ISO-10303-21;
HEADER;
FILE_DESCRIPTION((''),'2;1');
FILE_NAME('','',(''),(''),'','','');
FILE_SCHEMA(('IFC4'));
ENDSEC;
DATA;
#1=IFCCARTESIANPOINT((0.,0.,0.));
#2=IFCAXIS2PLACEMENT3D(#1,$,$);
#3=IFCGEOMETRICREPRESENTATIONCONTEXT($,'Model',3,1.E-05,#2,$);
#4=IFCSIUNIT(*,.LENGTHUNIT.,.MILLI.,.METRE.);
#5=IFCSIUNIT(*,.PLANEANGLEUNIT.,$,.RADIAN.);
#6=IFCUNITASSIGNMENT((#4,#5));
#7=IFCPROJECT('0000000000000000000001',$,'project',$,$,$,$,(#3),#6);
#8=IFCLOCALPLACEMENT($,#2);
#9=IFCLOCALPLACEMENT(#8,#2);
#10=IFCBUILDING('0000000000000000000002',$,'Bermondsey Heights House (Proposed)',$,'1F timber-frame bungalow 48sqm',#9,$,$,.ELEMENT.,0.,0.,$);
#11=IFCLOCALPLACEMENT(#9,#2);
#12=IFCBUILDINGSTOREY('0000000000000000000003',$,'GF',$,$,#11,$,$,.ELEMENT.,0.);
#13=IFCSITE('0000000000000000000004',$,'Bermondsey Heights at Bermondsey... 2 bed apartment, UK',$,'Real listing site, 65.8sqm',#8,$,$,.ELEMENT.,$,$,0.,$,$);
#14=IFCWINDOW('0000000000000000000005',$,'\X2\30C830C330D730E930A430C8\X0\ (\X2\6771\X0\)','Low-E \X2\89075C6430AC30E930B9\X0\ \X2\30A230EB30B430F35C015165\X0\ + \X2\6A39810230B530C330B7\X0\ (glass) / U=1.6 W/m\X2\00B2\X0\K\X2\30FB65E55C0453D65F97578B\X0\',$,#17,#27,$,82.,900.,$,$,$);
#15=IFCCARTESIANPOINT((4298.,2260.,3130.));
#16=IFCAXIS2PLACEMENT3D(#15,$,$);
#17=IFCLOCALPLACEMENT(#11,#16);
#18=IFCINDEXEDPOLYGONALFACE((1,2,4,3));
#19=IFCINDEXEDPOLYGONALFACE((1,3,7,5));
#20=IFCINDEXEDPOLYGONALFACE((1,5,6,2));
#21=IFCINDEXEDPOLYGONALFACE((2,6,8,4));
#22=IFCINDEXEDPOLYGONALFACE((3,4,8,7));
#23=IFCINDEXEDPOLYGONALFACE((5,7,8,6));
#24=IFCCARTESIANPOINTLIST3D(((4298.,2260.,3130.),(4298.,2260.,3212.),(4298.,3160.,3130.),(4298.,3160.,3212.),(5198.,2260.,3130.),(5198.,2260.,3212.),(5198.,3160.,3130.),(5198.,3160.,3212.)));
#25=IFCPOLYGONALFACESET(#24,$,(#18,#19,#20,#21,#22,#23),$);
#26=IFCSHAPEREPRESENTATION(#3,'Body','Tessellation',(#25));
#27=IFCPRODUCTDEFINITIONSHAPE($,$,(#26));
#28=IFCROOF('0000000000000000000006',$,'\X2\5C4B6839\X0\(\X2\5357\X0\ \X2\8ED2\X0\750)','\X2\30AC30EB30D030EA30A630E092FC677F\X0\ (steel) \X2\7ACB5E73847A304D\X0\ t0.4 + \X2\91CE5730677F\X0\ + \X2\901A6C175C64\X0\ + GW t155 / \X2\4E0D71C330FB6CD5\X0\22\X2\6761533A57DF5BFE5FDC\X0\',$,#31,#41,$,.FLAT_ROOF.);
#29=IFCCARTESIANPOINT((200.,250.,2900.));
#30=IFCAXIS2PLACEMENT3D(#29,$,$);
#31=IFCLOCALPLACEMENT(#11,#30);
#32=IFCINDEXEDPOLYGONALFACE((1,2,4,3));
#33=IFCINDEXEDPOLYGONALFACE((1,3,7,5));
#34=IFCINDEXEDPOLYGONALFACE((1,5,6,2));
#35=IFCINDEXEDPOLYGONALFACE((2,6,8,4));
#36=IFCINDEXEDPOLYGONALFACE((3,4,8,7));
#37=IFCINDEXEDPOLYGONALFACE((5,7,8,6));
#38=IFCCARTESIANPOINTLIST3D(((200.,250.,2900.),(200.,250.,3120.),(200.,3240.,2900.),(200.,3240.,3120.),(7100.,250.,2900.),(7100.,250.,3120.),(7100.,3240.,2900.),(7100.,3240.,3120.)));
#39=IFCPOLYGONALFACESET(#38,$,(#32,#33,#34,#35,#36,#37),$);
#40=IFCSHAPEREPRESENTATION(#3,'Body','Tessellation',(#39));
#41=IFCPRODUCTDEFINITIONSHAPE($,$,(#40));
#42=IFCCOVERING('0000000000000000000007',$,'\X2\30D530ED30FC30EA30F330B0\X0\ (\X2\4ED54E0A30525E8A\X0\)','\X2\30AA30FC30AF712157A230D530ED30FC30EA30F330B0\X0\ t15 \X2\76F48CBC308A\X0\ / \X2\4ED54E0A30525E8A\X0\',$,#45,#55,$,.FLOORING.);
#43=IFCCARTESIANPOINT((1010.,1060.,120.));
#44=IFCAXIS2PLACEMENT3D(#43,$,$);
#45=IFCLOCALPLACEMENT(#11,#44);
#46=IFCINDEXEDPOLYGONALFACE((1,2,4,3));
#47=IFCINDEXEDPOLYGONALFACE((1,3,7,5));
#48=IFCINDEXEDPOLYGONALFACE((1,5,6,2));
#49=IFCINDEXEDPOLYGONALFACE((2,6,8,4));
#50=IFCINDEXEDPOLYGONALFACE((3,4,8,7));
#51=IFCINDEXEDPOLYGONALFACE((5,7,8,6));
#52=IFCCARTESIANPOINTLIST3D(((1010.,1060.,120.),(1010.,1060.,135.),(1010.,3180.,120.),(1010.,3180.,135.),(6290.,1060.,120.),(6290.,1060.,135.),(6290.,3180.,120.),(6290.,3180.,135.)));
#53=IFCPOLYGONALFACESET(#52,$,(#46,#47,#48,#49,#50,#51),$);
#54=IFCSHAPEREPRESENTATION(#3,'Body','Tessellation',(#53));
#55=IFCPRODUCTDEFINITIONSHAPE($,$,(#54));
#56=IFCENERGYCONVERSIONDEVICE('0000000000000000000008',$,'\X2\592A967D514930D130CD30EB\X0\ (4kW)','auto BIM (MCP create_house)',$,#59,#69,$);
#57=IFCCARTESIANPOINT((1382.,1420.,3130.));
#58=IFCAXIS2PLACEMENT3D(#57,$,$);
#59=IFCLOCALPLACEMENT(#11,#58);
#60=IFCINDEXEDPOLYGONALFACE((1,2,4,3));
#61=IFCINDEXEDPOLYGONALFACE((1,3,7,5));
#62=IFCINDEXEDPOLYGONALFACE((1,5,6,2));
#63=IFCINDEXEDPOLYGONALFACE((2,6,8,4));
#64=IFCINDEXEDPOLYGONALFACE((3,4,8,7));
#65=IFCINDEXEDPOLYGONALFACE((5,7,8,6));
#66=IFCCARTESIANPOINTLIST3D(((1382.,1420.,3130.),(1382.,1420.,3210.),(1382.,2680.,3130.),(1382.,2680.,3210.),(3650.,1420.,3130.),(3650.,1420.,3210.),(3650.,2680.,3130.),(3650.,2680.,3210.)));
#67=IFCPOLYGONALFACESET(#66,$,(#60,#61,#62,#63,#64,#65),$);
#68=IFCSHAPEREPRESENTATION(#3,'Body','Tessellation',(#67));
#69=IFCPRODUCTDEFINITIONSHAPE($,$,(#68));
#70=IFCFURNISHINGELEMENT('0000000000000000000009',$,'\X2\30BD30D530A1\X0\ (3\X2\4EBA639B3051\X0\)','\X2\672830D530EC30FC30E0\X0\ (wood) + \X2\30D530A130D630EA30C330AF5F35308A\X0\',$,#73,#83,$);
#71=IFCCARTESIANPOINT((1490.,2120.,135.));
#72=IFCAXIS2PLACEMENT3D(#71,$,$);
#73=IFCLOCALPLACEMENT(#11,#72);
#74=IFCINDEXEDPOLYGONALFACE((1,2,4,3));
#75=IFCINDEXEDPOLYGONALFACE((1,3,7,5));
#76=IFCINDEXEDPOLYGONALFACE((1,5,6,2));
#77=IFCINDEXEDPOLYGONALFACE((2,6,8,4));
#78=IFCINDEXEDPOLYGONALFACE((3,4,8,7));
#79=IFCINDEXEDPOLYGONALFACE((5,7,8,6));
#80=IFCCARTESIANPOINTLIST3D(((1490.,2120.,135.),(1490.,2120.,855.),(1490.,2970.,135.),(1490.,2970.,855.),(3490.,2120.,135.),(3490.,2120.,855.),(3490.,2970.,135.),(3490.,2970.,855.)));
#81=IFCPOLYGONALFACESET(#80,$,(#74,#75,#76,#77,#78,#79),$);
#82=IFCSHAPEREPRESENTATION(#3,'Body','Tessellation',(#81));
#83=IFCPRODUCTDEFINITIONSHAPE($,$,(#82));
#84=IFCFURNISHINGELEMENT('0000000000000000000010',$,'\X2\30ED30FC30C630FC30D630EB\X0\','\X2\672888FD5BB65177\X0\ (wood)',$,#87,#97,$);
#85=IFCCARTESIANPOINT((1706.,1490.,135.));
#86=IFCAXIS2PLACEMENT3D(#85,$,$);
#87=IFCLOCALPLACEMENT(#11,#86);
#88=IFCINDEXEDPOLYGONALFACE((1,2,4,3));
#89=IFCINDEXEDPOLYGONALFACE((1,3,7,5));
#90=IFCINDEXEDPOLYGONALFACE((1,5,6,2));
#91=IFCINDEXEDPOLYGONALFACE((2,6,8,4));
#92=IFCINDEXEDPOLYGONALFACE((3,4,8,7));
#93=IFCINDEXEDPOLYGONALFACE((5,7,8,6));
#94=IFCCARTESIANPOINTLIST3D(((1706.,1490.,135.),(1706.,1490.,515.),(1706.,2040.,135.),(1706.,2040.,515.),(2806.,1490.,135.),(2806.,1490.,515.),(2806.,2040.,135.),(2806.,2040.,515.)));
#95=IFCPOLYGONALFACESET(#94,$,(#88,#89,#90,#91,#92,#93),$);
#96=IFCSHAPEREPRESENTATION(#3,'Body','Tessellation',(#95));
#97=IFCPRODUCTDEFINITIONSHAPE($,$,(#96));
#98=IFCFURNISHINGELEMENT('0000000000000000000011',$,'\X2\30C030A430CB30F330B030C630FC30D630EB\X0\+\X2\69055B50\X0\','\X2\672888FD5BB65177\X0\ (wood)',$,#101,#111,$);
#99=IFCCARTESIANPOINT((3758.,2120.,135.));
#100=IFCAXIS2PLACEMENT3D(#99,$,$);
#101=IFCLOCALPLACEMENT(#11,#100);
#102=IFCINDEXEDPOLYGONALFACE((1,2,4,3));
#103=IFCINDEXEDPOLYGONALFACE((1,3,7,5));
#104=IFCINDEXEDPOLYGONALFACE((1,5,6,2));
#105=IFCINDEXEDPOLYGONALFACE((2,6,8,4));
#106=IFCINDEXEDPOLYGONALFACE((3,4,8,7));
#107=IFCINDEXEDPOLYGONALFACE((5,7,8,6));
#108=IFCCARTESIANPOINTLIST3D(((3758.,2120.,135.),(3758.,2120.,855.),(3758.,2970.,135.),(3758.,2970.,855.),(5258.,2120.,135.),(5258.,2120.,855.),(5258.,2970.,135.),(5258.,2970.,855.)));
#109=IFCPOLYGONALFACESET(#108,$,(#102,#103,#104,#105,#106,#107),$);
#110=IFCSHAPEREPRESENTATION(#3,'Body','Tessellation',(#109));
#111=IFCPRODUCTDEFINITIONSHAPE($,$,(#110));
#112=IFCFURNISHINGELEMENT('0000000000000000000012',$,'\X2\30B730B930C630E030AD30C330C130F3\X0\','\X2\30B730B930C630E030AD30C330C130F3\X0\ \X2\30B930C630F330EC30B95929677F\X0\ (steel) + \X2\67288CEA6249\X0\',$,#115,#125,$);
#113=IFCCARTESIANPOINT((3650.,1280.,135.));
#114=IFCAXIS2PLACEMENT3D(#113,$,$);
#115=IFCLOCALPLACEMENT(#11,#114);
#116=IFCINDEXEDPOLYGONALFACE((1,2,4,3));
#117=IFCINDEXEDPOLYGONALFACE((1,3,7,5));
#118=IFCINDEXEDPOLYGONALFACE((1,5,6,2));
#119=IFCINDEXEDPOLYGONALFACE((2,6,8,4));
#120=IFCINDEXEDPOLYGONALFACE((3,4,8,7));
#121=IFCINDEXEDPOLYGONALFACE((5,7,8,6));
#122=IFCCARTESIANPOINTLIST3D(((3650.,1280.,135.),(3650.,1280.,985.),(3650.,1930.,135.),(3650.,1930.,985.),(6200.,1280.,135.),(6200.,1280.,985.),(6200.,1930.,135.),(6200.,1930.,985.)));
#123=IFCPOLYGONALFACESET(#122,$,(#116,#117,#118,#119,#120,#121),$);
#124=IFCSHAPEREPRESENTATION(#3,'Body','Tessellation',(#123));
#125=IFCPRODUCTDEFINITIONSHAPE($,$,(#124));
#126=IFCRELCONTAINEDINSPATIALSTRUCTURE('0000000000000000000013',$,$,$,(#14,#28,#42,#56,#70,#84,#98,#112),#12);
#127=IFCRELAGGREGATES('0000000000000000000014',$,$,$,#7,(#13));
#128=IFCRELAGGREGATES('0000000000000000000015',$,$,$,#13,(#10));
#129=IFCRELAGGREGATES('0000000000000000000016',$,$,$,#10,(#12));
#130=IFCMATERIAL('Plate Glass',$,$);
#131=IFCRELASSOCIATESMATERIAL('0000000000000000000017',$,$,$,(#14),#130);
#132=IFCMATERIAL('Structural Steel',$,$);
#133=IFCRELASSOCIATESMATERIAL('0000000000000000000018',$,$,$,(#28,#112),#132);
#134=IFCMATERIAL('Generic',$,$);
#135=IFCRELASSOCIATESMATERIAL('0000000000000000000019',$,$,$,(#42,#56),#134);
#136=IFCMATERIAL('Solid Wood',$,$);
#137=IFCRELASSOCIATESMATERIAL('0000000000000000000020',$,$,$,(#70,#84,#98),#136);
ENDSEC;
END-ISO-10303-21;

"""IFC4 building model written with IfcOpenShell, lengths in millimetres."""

from ifc_helpers import new_model, si_unit, frame, frame_2d, origin, place, context, project, spatial, rectangle, extrude, material, element, save


model = new_model("IFC4")

# Units and contexts
model_context = context("Model", 3, precision=1e-05, world=origin())
ifc_project = project(units=[si_unit("LENGTHUNIT", "METRE", prefix="MILLI"), si_unit("PLANEANGLEUNIT", "RADIAN")], contexts=[model_context])

# Site, building, storey
site_placement = place(None, origin())
site = spatial("IfcSite", under=ifc_project, at=site_placement, Name="Bermondsey Heights at Bermondsey... 2 bed apartment, UK", ObjectType="Real listing site, 65.8sqm", CompositionType="ELEMENT", RefElevation=0.0)
building_placement = place(site_placement, origin())
building = spatial("IfcBuilding", under=site, at=building_placement, Name="Bermondsey Heights House (Proposed)", ObjectType="1F timber-frame bungalow 48sqm", CompositionType="ELEMENT", ElevationOfRefHeight=0.0, ElevationOfTerrain=0.0)
storey_placement = place(building_placement, origin())
storey = spatial("IfcBuildingStorey", under=building, at=storey_placement, Name="GF", CompositionType="ELEMENT", Elevation=0.0)

# Shared definitions
ifc_material_1 = material(Name="Solid Wood")
ifc_material_2 = material(Name="Generic")

# Shared definitions
ifc_material_3 = material(Name="Plate Glass")

# Window
window_1_placement = place(storey_placement, frame((4298.0, 2260.0, 3130.0)))
element("IfcWindow", 1, at=window_1_placement, inside=storey, material=ifc_material_3, Name="トップライト (東)", Description="Low-E 複層ガラス アルゴン封入 + 樹脂サッシ (glass) / U=1.6 W/m²K・日射取得型", OverallHeight=82.0, OverallWidth=900.0, context=model_context, shape_type="SweptSolid", body=[
    extrude(rectangle(XDim=900.0, YDim=900.0, at=frame_2d((450.0, 450.0))), frame((4298.0, 2260.0, 3130.0)), (0.0, 0.0, 1.0), 82.0),
])

# Roof
ifc_material_4 = material(Name="Structural Steel")
roof_placement = place(storey_placement, frame((200.0, 250.0, 2900.0)))
element("IfcRoof", 2, at=roof_placement, inside=storey, material=ifc_material_4, Name="屋根(南 軒750)", Description="ガルバリウム鋼板 (steel) 立平葺き t0.4 + 野地板 + 通気層 + GW t155 / 不燃・法22条区域対応", PredefinedType="FLAT_ROOF", context=model_context, shape_type="SweptSolid", body=[
    extrude(rectangle(XDim=6900.0, YDim=2990.0, at=frame_2d((3450.0, 1495.0))), frame((200.0, 250.0, 2900.0)), (0.0, 0.0, 1.0), 220.0),
])

# Covering
covering_placement = place(storey_placement, frame((1010.0, 1060.0, 120.0)))
element("IfcCovering", 3, at=covering_placement, inside=storey, material=ifc_material_2, Name="フローリング (仕上げ床)", Description="オーク無垢フローリング t15 直貼り / 仕上げ床", PredefinedType="FLOORING", context=model_context, shape_type="SweptSolid", body=[
    extrude(rectangle(XDim=5280.0, YDim=2120.0, at=frame_2d((2640.0, 1060.0))), frame((1010.0, 1060.0, 120.0)), (0.0, 0.0, 1.0), 15.0),
])

# Energy conversion device
energy_conversion_device_placement = place(storey_placement, frame((1382.0, 1420.0, 3130.0)))
element("IfcEnergyConversionDevice", 4, at=energy_conversion_device_placement, inside=storey, material=ifc_material_2, Name="太陽光パネル (4kW)", Description="auto BIM (MCP create_house)", context=model_context, shape_type="SweptSolid", body=[
    extrude(rectangle(XDim=2268.0, YDim=1260.0, at=frame_2d((1134.0, 630.0))), frame((1382.0, 1420.0, 3130.0)), (0.0, 0.0, 1.0), 80.0),
])

# Furnishing elements
furnishing_1_placement = place(storey_placement, frame((1490.0, 2120.0, 135.0)))
element("IfcFurnishingElement", 5, at=furnishing_1_placement, inside=storey, material=ifc_material_1, Name="ソファ (3人掛け)", Description="木フレーム (wood) + ファブリック張り", context=model_context, shape_type="SweptSolid", body=[
    extrude(rectangle(XDim=2000.0, YDim=850.0, at=frame_2d((1000.0, 425.0))), frame((1490.0, 2120.0, 135.0)), (0.0, 0.0, 1.0), 720.0),
])
furnishing_2_placement = place(storey_placement, frame((1706.0, 1490.0, 135.0)))
element("IfcFurnishingElement", 6, at=furnishing_2_placement, inside=storey, material=ifc_material_1, Name="ローテーブル", Description="木製家具 (wood)", context=model_context, shape_type="SweptSolid", body=[
    extrude(rectangle(XDim=1100.0, YDim=550.0, at=frame_2d((550.0, 275.0))), frame((1706.0, 1490.0, 135.0)), (0.0, 0.0, 1.0), 380.0),
])
furnishing_3_placement = place(storey_placement, frame((3758.0, 2120.0, 135.0)))
element("IfcFurnishingElement", 7, at=furnishing_3_placement, inside=storey, material=ifc_material_1, Name="ダイニングテーブル+椅子", Description="木製家具 (wood)", context=model_context, shape_type="SweptSolid", body=[
    extrude(rectangle(XDim=1500.0, YDim=850.0, at=frame_2d((750.0, 425.0))), frame((3758.0, 2120.0, 135.0)), (0.0, 0.0, 1.0), 720.0),
])
furnishing_4_placement = place(storey_placement, frame((3650.0, 1280.0, 135.0)))
element("IfcFurnishingElement", 8, at=furnishing_4_placement, inside=storey, material=ifc_material_4, Name="システムキッチン", Description="システムキッチン ステンレス天板 (steel) + 木質扉", context=model_context, shape_type="SweptSolid", body=[
    extrude(rectangle(XDim=2550.0, YDim=650.0, at=frame_2d((1275.0, 325.0))), frame((3650.0, 1280.0, 135.0)), (0.0, 0.0, 1.0), 850.0),
])

save(model, "model.ifc")
